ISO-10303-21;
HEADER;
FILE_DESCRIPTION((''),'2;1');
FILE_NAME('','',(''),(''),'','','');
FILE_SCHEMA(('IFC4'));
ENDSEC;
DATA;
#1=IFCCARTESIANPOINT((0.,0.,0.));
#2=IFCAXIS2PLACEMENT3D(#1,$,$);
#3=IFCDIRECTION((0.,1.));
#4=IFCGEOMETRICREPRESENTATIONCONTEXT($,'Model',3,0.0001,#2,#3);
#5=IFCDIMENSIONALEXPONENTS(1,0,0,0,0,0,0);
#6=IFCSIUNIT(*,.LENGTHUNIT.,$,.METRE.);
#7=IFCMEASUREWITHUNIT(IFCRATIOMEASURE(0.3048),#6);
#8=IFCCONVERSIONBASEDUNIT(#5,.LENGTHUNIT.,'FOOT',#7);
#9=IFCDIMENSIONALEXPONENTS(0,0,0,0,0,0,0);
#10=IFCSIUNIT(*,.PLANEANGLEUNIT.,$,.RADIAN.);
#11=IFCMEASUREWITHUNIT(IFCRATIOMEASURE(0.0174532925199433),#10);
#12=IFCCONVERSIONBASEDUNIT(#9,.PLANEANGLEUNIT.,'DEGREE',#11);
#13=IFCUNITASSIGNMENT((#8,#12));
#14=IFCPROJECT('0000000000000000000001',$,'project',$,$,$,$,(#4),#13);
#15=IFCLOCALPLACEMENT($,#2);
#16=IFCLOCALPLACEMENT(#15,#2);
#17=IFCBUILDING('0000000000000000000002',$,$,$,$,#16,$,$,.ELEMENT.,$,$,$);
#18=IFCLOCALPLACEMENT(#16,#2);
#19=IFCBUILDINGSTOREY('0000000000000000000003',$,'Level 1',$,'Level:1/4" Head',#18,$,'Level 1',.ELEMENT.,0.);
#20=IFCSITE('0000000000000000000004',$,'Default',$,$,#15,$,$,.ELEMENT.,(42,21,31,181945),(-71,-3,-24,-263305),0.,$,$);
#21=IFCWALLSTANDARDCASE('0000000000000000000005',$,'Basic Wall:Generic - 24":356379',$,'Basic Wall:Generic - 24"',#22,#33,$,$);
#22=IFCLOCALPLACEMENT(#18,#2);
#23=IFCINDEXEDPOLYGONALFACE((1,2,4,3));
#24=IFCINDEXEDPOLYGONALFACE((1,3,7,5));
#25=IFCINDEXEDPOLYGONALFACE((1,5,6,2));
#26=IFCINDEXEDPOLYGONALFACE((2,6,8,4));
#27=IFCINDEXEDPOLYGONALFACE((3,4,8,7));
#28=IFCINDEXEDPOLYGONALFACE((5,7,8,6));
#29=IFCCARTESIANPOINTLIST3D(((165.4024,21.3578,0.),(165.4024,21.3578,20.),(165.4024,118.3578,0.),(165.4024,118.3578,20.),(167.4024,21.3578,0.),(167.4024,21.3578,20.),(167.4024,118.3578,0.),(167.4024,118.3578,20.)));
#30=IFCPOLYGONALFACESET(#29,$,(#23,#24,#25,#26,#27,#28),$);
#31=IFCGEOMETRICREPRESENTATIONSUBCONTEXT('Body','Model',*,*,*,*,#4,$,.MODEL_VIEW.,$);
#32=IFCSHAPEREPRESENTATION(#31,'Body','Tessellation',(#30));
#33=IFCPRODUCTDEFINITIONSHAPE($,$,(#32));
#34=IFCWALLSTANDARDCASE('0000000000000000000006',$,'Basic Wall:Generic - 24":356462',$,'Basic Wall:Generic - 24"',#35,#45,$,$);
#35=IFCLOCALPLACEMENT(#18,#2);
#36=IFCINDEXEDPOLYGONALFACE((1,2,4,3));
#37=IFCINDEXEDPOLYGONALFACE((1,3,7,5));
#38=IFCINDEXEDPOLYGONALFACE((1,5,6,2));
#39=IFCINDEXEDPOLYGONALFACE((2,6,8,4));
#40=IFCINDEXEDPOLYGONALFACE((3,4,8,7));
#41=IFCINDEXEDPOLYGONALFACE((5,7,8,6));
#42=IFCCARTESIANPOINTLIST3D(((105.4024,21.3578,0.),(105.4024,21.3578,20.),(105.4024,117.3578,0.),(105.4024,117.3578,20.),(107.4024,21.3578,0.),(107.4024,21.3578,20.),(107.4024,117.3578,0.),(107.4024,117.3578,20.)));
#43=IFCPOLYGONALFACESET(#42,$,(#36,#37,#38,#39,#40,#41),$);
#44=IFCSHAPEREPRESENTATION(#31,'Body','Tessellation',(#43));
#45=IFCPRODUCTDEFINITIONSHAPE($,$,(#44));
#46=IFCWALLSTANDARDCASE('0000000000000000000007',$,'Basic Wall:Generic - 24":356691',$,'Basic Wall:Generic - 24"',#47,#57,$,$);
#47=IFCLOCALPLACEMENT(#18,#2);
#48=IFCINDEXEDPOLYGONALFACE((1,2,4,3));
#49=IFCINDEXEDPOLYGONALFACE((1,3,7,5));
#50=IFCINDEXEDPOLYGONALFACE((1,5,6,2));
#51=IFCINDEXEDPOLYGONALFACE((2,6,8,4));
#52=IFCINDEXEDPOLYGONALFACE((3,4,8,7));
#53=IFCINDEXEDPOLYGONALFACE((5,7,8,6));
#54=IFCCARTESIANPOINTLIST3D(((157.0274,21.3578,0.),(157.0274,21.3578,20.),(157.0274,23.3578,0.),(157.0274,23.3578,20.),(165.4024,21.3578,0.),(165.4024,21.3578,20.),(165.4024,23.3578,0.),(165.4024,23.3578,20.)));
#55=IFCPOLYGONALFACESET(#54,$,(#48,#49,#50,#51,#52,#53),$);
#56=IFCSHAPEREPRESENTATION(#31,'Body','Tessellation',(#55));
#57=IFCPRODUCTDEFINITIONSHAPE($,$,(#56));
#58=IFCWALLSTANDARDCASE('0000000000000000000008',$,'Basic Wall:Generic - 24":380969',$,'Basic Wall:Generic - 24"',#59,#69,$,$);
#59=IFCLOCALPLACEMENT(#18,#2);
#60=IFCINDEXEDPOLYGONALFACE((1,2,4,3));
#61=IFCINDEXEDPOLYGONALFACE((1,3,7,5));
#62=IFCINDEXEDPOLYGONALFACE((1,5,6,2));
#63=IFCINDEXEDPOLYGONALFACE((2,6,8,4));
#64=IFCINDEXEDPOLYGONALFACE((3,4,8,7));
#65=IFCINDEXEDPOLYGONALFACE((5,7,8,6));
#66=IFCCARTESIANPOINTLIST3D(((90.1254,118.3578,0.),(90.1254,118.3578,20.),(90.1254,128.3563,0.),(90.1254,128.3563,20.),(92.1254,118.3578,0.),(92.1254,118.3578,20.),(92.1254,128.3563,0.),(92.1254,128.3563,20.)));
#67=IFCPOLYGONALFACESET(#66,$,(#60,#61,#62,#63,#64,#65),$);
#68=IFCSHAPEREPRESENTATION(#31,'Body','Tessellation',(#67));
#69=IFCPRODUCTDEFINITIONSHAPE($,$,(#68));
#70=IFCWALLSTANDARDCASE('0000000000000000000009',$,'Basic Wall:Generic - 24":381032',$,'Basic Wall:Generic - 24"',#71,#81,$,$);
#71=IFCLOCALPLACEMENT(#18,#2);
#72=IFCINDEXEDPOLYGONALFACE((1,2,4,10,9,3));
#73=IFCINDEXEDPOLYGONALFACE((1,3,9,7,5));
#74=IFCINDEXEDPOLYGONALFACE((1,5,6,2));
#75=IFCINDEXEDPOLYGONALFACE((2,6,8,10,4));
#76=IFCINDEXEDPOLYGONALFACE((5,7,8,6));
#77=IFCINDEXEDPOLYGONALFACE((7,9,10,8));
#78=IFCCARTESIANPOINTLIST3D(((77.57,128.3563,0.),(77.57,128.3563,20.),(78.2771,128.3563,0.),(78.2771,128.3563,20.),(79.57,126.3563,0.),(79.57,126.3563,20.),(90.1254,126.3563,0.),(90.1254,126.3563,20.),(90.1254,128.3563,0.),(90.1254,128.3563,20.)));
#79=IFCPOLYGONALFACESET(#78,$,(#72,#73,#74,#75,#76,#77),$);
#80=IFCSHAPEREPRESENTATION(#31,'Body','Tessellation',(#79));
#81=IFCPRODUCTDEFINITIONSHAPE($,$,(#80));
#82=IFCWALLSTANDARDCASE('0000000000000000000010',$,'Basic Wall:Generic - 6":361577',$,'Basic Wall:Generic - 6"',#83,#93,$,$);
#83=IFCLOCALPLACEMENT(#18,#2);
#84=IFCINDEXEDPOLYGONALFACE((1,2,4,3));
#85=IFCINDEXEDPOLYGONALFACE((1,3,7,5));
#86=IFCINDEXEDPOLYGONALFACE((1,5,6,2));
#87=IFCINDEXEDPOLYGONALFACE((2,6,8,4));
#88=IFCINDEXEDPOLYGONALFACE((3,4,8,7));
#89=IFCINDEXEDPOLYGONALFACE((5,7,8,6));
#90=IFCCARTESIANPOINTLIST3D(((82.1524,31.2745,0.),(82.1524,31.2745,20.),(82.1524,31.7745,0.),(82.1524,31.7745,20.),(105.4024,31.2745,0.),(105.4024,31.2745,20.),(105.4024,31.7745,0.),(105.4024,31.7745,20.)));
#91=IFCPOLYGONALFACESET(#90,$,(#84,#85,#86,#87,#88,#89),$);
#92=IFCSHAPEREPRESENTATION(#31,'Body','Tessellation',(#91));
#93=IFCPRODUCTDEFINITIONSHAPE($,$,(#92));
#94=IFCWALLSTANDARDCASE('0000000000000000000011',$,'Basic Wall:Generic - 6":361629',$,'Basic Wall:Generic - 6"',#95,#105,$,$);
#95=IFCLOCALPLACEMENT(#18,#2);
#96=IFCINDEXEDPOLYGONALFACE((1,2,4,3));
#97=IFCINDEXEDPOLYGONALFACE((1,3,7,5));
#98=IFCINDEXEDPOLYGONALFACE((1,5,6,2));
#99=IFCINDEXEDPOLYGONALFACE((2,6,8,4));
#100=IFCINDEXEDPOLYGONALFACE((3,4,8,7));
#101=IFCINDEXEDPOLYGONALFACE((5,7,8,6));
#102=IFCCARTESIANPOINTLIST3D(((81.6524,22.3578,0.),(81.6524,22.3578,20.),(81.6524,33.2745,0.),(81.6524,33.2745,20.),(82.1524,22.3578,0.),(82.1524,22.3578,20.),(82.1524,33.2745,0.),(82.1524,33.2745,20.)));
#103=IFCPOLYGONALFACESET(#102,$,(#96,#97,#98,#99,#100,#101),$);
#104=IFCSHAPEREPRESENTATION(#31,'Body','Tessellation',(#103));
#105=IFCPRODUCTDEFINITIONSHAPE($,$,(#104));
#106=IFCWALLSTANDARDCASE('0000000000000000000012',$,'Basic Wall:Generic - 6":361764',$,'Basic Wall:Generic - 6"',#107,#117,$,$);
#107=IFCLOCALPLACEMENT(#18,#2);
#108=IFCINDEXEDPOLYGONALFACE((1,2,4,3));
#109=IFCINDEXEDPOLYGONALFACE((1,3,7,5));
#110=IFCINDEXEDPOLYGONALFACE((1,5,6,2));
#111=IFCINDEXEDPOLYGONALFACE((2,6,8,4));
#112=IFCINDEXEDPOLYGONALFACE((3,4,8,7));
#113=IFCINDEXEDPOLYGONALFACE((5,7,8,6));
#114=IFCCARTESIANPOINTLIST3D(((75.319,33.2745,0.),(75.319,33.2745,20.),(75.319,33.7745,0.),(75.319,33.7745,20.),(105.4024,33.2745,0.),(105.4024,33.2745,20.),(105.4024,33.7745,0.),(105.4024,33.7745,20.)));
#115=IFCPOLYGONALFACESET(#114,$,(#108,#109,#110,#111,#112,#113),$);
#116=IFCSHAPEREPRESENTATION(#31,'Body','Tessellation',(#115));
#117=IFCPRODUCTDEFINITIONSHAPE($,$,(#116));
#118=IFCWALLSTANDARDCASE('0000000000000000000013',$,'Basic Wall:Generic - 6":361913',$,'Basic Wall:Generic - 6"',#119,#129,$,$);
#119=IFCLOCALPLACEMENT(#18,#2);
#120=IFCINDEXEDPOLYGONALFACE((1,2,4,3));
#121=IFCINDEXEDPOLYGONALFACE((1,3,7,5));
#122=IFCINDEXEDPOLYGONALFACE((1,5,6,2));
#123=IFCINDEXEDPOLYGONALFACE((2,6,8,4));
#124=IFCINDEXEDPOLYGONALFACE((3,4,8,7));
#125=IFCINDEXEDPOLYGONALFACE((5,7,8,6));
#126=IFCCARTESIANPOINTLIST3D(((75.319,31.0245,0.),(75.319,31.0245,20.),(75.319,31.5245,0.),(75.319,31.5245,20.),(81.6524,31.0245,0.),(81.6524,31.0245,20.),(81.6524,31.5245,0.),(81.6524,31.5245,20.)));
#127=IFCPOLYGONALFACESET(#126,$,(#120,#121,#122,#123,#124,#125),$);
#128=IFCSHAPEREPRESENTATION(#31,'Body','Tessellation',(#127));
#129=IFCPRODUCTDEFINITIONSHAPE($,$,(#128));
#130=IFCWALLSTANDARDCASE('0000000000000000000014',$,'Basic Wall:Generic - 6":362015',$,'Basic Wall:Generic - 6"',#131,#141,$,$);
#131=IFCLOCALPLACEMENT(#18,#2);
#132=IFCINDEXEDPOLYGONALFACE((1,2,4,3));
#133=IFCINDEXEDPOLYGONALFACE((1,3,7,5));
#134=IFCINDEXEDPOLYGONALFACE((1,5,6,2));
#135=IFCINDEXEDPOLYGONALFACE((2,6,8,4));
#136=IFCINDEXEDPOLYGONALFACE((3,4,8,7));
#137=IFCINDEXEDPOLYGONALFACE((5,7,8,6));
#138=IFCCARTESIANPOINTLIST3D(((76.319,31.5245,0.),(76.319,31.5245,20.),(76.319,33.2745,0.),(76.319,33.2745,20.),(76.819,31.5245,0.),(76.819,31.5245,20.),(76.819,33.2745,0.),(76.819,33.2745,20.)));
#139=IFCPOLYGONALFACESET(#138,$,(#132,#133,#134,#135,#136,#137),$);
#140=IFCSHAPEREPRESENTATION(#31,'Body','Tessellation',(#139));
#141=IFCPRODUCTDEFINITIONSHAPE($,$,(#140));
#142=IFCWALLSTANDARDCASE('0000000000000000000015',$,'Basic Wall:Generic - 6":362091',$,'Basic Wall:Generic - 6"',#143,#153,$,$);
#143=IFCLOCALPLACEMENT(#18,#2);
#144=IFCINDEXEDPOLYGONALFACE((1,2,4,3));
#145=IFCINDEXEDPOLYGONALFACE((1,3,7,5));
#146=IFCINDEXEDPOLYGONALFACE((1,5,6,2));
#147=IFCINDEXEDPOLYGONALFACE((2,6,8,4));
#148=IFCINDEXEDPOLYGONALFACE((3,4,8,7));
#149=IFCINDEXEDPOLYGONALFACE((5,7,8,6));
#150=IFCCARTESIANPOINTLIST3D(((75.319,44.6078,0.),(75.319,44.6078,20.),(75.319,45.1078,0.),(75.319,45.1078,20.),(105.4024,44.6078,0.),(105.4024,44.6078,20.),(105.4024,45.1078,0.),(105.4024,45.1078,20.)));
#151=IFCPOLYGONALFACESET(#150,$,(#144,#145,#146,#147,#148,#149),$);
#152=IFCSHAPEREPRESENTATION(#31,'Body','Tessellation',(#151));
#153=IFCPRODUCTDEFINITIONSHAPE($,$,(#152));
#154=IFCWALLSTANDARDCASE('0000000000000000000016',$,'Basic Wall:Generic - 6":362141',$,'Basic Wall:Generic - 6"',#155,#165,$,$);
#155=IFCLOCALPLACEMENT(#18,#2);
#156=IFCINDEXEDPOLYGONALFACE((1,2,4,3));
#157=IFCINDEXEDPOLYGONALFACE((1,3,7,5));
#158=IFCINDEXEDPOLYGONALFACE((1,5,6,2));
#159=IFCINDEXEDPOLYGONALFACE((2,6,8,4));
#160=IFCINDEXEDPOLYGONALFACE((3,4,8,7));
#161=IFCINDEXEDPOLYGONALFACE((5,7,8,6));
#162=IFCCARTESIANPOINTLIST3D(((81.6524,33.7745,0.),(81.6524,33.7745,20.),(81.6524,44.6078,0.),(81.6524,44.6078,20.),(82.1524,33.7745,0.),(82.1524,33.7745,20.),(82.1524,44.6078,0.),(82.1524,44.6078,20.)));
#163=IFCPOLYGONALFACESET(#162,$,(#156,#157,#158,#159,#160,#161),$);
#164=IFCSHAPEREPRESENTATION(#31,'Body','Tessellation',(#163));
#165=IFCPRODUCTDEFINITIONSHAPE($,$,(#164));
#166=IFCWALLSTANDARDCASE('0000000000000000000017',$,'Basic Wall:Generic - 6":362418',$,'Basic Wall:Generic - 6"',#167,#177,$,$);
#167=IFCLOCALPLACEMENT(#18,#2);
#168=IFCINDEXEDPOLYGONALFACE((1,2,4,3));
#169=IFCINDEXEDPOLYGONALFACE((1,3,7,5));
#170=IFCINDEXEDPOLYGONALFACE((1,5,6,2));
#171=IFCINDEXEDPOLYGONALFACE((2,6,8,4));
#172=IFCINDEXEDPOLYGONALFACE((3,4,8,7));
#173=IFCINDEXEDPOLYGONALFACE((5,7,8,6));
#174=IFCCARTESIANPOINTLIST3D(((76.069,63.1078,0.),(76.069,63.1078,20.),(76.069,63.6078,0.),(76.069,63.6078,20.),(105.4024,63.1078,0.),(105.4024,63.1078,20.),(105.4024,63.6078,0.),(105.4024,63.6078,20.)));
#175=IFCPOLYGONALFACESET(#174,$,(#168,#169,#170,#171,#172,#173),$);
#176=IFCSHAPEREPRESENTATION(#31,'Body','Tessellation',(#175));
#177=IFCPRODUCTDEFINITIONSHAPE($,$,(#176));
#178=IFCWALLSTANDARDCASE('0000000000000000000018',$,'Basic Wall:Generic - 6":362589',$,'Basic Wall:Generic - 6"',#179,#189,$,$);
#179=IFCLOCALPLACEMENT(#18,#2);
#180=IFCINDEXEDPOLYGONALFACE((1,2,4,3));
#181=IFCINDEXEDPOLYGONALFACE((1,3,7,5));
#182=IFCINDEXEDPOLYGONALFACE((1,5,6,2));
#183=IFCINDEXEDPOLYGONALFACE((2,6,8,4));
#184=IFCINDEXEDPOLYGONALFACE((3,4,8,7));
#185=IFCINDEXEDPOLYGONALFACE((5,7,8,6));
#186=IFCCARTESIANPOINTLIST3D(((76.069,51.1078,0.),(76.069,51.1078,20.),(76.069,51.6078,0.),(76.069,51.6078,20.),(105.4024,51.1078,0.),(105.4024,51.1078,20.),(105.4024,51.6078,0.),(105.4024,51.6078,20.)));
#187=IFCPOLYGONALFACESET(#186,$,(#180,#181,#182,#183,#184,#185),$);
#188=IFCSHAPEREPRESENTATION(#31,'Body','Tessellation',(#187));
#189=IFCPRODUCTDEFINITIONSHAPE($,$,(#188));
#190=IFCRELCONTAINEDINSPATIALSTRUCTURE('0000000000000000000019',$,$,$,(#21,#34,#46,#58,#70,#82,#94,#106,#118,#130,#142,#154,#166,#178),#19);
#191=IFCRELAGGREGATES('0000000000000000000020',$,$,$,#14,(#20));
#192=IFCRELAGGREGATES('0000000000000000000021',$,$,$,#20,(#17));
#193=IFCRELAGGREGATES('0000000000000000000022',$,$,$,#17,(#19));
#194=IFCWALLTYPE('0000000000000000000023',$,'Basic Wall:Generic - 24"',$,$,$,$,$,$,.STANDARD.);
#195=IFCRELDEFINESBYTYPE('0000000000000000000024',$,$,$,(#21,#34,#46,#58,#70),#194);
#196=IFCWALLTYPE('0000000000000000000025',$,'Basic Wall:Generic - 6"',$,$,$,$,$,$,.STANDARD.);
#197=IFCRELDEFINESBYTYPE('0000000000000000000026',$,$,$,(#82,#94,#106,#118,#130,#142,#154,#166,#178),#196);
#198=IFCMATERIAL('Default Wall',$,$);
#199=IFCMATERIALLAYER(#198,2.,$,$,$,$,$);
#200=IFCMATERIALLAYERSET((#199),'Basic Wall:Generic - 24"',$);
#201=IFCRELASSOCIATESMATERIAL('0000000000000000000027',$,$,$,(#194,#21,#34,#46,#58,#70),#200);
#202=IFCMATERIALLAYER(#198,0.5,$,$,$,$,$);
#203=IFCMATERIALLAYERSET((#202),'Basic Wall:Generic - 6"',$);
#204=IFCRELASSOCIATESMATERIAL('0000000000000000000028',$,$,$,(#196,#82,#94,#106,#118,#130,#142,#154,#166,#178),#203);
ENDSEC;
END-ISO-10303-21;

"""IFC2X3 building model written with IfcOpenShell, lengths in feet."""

from ifc_helpers import new_model, entity, si_unit, converted_unit, direction, frame, frame_2d, origin, place, context, subcontext, project, spatial, polyline, rectangle, outline, extrude, material, layer, layer_set, layer_usage, type_object, element, save


model = new_model("IFC2X3")

# Units and contexts
model_context = context("Model", 3, precision=0.0001, world=origin(), true_north=direction((0.0, 1.0)))
body_context = subcontext(model_context, "Body", "Model", "MODEL_VIEW")
ifc_project = project(units=[converted_unit("LENGTHUNIT", "FOOT", entity("IfcRatioMeasure", 0.3048), si_unit("LENGTHUNIT", "METRE"), dimensions=[1, 0, 0, 0, 0, 0, 0]), converted_unit("PLANEANGLEUNIT", "DEGREE", entity("IfcRatioMeasure", 0.0174532925199433), si_unit("PLANEANGLEUNIT", "RADIAN"), dimensions=[0, 0, 0, 0, 0, 0, 0])], contexts=[model_context])

# Site, building, storey
site_placement = place(None, origin())
site = spatial("IfcSite", under=ifc_project, at=site_placement, Name="Default", CompositionType="ELEMENT", RefLatitude=(42, 21, 31, 181945), RefLongitude=(-71, -3, -24, -263305), RefElevation=0.0)
building_placement = place(site_placement, origin())
building = spatial("IfcBuilding", under=site, at=building_placement, CompositionType="ELEMENT")
storey_placement = place(building_placement, origin())
storey = spatial("IfcBuildingStorey", under=building, at=storey_placement, Name="Level 1", ObjectType="Level:1/4\" Head", LongName="Level 1", CompositionType="ELEMENT", Elevation=0.0)

# Walls
ifc_material = material(Name="Default Wall")
ifc_layer_1 = layer(ifc_material, 2.0)
ifc_layer_set_1 = layer_set([ifc_layer_1], Name="Basic Wall:Generic - 24\"")
ifc_layer_usage_1 = layer_usage(ifc_layer_set_1, "AXIS2", "NEGATIVE", 1.0)
wall_type_1 = type_object("IfcWallType", Name="Basic Wall:Generic - 24\"", PredefinedType="STANDARD", material=ifc_layer_set_1)
wall_1_placement = place(storey_placement, frame((166.4024, 118.3578, 0.0), z_axis=(0.0, 0.0, 1.0), x_axis=(0.0, -1.0, 0.0)))
element("IfcWallStandardCase", 1, at=wall_1_placement, inside=storey, type_object=wall_type_1, material=ifc_layer_usage_1, Name="Basic Wall:Generic - 24\":356379", ObjectType="Basic Wall:Generic - 24\"", context=body_context, shape_type="SweptSolid", body=[
    extrude(rectangle(XDim=97.0, YDim=2.0, at=frame_2d((48.5, 0.0), x_axis=(-1.0, 0.0))), origin(), (0.0, 0.0, 1.0), 20.0),
])
ifc_layer_usage_2 = layer_usage(ifc_layer_set_1, "AXIS2", "NEGATIVE", 1.0)
wall_2_placement = place(storey_placement, frame((106.4024, 117.3578, 0.0), z_axis=(0.0, 0.0, 1.0), x_axis=(0.0, -1.0, 0.0)))
element("IfcWallStandardCase", 2, at=wall_2_placement, inside=storey, type_object=wall_type_1, material=ifc_layer_usage_2, Name="Basic Wall:Generic - 24\":356462", ObjectType="Basic Wall:Generic - 24\"", context=body_context, shape_type="SweptSolid", body=[
    extrude(rectangle(XDim=96.0, YDim=2.0, at=frame_2d((48.0, 0.0), x_axis=(-1.0, 0.0))), origin(), (0.0, 0.0, 1.0), 20.0),
])
ifc_layer_usage_3 = layer_usage(ifc_layer_set_1, "AXIS2", "NEGATIVE", 1.0)
wall_3_placement = place(storey_placement, frame((165.4024, 22.3578, 0.0), z_axis=(0.0, 0.0, 1.0), x_axis=(-1.0, 0.0, 0.0)))
element("IfcWallStandardCase", 3, at=wall_3_placement, inside=storey, type_object=wall_type_1, material=ifc_layer_usage_3, Name="Basic Wall:Generic - 24\":356691", ObjectType="Basic Wall:Generic - 24\"", context=body_context, shape_type="SweptSolid", body=[
    extrude(rectangle(XDim=8.375, YDim=2.0, at=frame_2d((4.1875, 0.0), x_axis=(-1.0, 0.0))), origin(), (0.0, 0.0, 1.0), 20.0),
])
ifc_layer_usage_4 = layer_usage(ifc_layer_set_1, "AXIS2", "NEGATIVE", 1.0)
wall_4_placement = place(storey_placement, frame((91.1254, 118.3578, 0.0), z_axis=(0.0, 0.0, 1.0), x_axis=(0.0, 1.0, 0.0)))
element("IfcWallStandardCase", 4, at=wall_4_placement, inside=storey, type_object=wall_type_1, material=ifc_layer_usage_4, Name="Basic Wall:Generic - 24\":380969", ObjectType="Basic Wall:Generic - 24\"", context=body_context, shape_type="SweptSolid", body=[
    extrude(rectangle(XDim=9.9985, YDim=2.0, at=frame_2d((4.9992, 0.0), x_axis=(-1.0, 0.0))), origin(), (0.0, 0.0, 1.0), 20.0),
])
ifc_layer_usage_5 = layer_usage(ifc_layer_set_1, "AXIS2", "NEGATIVE", 1.0)
wall_5_placement = place(storey_placement, frame((90.1254, 127.3563, 0.0), z_axis=(0.0, 0.0, 1.0), x_axis=(-1.0, 0.0, 0.0)))
element("IfcWallStandardCase", 5, at=wall_5_placement, inside=storey, type_object=wall_type_1, material=ifc_layer_usage_5, Name="Basic Wall:Generic - 24\":381032", ObjectType="Basic Wall:Generic - 24\"", context=body_context, shape_type="SweptSolid", body=[
    extrude(outline(polyline([(12.5555, -1.0), (10.5555, 1.0), (0.0, 1.0), (0.0, -1.0), (11.8484, -1.0), (12.5555, -1.0)])), origin(), (0.0, 0.0, 1.0), 20.0),
])
ifc_layer_2 = layer(ifc_material, 0.5)
ifc_layer_set_2 = layer_set([ifc_layer_2], Name="Basic Wall:Generic - 6\"")
ifc_layer_usage_6 = layer_usage(ifc_layer_set_2, "AXIS2", "NEGATIVE", 0.25)
wall_type_2 = type_object("IfcWallType", Name="Basic Wall:Generic - 6\"", PredefinedType="STANDARD", material=ifc_layer_set_2)
wall_6_placement = place(storey_placement, frame((105.4024, 31.5245, 0.0), z_axis=(0.0, 0.0, 1.0), x_axis=(-1.0, 0.0, 0.0)))
element("IfcWallStandardCase", 6, at=wall_6_placement, inside=storey, type_object=wall_type_2, material=ifc_layer_usage_6, Name="Basic Wall:Generic - 6\":361577", ObjectType="Basic Wall:Generic - 6\"", context=body_context, shape_type="SweptSolid", body=[
    extrude(rectangle(XDim=23.25, YDim=0.5, at=frame_2d((11.625, 0.0), x_axis=(-1.0, 0.0))), origin(), (0.0, 0.0, 1.0), 20.0),
])
ifc_layer_usage_7 = layer_usage(ifc_layer_set_2, "AXIS2", "NEGATIVE", 0.25)
wall_7_placement = place(storey_placement, frame((81.9024, 33.2745, 0.0), z_axis=(0.0, 0.0, 1.0), x_axis=(0.0, -1.0, 0.0)))
element("IfcWallStandardCase", 7, at=wall_7_placement, inside=storey, type_object=wall_type_2, material=ifc_layer_usage_7, Name="Basic Wall:Generic - 6\":361629", ObjectType="Basic Wall:Generic - 6\"", context=body_context, shape_type="SweptSolid", body=[
    extrude(rectangle(XDim=10.9167, YDim=0.5, at=frame_2d((5.4583, 0.0), x_axis=(-1.0, 0.0))), origin(), (0.0, 0.0, 1.0), 20.0),
])
ifc_layer_usage_8 = layer_usage(ifc_layer_set_2, "AXIS2", "NEGATIVE", 0.25)
wall_8_placement = place(storey_placement, frame((105.4024, 33.5245, 0.0), z_axis=(0.0, 0.0, 1.0), x_axis=(-1.0, 0.0, 0.0)))
element("IfcWallStandardCase", 8, at=wall_8_placement, inside=storey, type_object=wall_type_2, material=ifc_layer_usage_8, Name="Basic Wall:Generic - 6\":361764", ObjectType="Basic Wall:Generic - 6\"", context=body_context, shape_type="SweptSolid", body=[
    extrude(rectangle(XDim=30.0833, YDim=0.5, at=frame_2d((15.0417, 0.0), x_axis=(-1.0, 0.0))), origin(), (0.0, 0.0, 1.0), 20.0),
])
ifc_layer_usage_9 = layer_usage(ifc_layer_set_2, "AXIS2", "NEGATIVE", 0.25)
wall_9_placement = place(storey_placement, frame((81.6524, 31.2745, 0.0), z_axis=(0.0, 0.0, 1.0), x_axis=(-1.0, 0.0, 0.0)))
element("IfcWallStandardCase", 9, at=wall_9_placement, inside=storey, type_object=wall_type_2, material=ifc_layer_usage_9, Name="Basic Wall:Generic - 6\":361913", ObjectType="Basic Wall:Generic - 6\"", context=body_context, shape_type="SweptSolid", body=[
    extrude(rectangle(XDim=6.3333, YDim=0.5, at=frame_2d((3.1667, 0.0), x_axis=(-1.0, 0.0))), origin(), (0.0, 0.0, 1.0), 20.0),
])
ifc_layer_usage_10 = layer_usage(ifc_layer_set_2, "AXIS2", "NEGATIVE", 0.25)
wall_10_placement = place(storey_placement, frame((76.569, 33.2745, 0.0), z_axis=(0.0, 0.0, 1.0), x_axis=(0.0, -1.0, 0.0)))
element("IfcWallStandardCase", 10, at=wall_10_placement, inside=storey, type_object=wall_type_2, material=ifc_layer_usage_10, Name="Basic Wall:Generic - 6\":362015", ObjectType="Basic Wall:Generic - 6\"", context=body_context, shape_type="SweptSolid", body=[
    extrude(rectangle(XDim=1.75, YDim=0.5, at=frame_2d((0.875, 0.0), x_axis=(-1.0, 0.0))), origin(), (0.0, 0.0, 1.0), 20.0),
])
ifc_layer_usage_11 = layer_usage(ifc_layer_set_2, "AXIS2", "NEGATIVE", 0.25)
wall_11_placement = place(storey_placement, frame((105.4024, 44.8578, 0.0), z_axis=(0.0, 0.0, 1.0), x_axis=(-1.0, 0.0, 0.0)))
element("IfcWallStandardCase", 11, at=wall_11_placement, inside=storey, type_object=wall_type_2, material=ifc_layer_usage_11, Name="Basic Wall:Generic - 6\":362091", ObjectType="Basic Wall:Generic - 6\"", context=body_context, shape_type="SweptSolid", body=[
    extrude(rectangle(XDim=30.0833, YDim=0.5, at=frame_2d((15.0417, 0.0), x_axis=(-1.0, 0.0))), origin(), (0.0, 0.0, 1.0), 20.0),
])
ifc_layer_usage_12 = layer_usage(ifc_layer_set_2, "AXIS2", "NEGATIVE", 0.25)
wall_12_placement = place(storey_placement, frame((81.9024, 44.6078, 0.0), z_axis=(0.0, 0.0, 1.0), x_axis=(0.0, -1.0, 0.0)))
element("IfcWallStandardCase", 12, at=wall_12_placement, inside=storey, type_object=wall_type_2, material=ifc_layer_usage_12, Name="Basic Wall:Generic - 6\":362141", ObjectType="Basic Wall:Generic - 6\"", context=body_context, shape_type="SweptSolid", body=[
    extrude(rectangle(XDim=10.8333, YDim=0.5, at=frame_2d((5.4167, 0.0), x_axis=(-1.0, 0.0))), origin(), (0.0, 0.0, 1.0), 20.0),
])
ifc_layer_usage_13 = layer_usage(ifc_layer_set_2, "AXIS2", "NEGATIVE", 0.25)
wall_13_placement = place(storey_placement, frame((105.4024, 63.3578, 0.0), z_axis=(0.0, 0.0, 1.0), x_axis=(-1.0, 0.0, 0.0)))
element("IfcWallStandardCase", 13, at=wall_13_placement, inside=storey, type_object=wall_type_2, material=ifc_layer_usage_13, Name="Basic Wall:Generic - 6\":362418", ObjectType="Basic Wall:Generic - 6\"", context=body_context, shape_type="SweptSolid", body=[
    extrude(rectangle(XDim=29.3333, YDim=0.5, at=frame_2d((14.6667, 0.0), x_axis=(-1.0, 0.0))), origin(), (0.0, 0.0, 1.0), 20.0),
])
ifc_layer_usage_14 = layer_usage(ifc_layer_set_2, "AXIS2", "NEGATIVE", 0.25)
wall_14_placement = place(storey_placement, frame((76.069, 51.3578, 0.0)))
element("IfcWallStandardCase", 14, at=wall_14_placement, inside=storey, type_object=wall_type_2, material=ifc_layer_usage_14, Name="Basic Wall:Generic - 6\":362589", ObjectType="Basic Wall:Generic - 6\"", context=body_context, shape_type="SweptSolid", body=[
    extrude(rectangle(XDim=29.3333, YDim=0.5, at=frame_2d((14.6667, 0.0), x_axis=(-1.0, 0.0))), origin(), (0.0, 0.0, 1.0), 20.0),
])

save(model, "model.ifc")
